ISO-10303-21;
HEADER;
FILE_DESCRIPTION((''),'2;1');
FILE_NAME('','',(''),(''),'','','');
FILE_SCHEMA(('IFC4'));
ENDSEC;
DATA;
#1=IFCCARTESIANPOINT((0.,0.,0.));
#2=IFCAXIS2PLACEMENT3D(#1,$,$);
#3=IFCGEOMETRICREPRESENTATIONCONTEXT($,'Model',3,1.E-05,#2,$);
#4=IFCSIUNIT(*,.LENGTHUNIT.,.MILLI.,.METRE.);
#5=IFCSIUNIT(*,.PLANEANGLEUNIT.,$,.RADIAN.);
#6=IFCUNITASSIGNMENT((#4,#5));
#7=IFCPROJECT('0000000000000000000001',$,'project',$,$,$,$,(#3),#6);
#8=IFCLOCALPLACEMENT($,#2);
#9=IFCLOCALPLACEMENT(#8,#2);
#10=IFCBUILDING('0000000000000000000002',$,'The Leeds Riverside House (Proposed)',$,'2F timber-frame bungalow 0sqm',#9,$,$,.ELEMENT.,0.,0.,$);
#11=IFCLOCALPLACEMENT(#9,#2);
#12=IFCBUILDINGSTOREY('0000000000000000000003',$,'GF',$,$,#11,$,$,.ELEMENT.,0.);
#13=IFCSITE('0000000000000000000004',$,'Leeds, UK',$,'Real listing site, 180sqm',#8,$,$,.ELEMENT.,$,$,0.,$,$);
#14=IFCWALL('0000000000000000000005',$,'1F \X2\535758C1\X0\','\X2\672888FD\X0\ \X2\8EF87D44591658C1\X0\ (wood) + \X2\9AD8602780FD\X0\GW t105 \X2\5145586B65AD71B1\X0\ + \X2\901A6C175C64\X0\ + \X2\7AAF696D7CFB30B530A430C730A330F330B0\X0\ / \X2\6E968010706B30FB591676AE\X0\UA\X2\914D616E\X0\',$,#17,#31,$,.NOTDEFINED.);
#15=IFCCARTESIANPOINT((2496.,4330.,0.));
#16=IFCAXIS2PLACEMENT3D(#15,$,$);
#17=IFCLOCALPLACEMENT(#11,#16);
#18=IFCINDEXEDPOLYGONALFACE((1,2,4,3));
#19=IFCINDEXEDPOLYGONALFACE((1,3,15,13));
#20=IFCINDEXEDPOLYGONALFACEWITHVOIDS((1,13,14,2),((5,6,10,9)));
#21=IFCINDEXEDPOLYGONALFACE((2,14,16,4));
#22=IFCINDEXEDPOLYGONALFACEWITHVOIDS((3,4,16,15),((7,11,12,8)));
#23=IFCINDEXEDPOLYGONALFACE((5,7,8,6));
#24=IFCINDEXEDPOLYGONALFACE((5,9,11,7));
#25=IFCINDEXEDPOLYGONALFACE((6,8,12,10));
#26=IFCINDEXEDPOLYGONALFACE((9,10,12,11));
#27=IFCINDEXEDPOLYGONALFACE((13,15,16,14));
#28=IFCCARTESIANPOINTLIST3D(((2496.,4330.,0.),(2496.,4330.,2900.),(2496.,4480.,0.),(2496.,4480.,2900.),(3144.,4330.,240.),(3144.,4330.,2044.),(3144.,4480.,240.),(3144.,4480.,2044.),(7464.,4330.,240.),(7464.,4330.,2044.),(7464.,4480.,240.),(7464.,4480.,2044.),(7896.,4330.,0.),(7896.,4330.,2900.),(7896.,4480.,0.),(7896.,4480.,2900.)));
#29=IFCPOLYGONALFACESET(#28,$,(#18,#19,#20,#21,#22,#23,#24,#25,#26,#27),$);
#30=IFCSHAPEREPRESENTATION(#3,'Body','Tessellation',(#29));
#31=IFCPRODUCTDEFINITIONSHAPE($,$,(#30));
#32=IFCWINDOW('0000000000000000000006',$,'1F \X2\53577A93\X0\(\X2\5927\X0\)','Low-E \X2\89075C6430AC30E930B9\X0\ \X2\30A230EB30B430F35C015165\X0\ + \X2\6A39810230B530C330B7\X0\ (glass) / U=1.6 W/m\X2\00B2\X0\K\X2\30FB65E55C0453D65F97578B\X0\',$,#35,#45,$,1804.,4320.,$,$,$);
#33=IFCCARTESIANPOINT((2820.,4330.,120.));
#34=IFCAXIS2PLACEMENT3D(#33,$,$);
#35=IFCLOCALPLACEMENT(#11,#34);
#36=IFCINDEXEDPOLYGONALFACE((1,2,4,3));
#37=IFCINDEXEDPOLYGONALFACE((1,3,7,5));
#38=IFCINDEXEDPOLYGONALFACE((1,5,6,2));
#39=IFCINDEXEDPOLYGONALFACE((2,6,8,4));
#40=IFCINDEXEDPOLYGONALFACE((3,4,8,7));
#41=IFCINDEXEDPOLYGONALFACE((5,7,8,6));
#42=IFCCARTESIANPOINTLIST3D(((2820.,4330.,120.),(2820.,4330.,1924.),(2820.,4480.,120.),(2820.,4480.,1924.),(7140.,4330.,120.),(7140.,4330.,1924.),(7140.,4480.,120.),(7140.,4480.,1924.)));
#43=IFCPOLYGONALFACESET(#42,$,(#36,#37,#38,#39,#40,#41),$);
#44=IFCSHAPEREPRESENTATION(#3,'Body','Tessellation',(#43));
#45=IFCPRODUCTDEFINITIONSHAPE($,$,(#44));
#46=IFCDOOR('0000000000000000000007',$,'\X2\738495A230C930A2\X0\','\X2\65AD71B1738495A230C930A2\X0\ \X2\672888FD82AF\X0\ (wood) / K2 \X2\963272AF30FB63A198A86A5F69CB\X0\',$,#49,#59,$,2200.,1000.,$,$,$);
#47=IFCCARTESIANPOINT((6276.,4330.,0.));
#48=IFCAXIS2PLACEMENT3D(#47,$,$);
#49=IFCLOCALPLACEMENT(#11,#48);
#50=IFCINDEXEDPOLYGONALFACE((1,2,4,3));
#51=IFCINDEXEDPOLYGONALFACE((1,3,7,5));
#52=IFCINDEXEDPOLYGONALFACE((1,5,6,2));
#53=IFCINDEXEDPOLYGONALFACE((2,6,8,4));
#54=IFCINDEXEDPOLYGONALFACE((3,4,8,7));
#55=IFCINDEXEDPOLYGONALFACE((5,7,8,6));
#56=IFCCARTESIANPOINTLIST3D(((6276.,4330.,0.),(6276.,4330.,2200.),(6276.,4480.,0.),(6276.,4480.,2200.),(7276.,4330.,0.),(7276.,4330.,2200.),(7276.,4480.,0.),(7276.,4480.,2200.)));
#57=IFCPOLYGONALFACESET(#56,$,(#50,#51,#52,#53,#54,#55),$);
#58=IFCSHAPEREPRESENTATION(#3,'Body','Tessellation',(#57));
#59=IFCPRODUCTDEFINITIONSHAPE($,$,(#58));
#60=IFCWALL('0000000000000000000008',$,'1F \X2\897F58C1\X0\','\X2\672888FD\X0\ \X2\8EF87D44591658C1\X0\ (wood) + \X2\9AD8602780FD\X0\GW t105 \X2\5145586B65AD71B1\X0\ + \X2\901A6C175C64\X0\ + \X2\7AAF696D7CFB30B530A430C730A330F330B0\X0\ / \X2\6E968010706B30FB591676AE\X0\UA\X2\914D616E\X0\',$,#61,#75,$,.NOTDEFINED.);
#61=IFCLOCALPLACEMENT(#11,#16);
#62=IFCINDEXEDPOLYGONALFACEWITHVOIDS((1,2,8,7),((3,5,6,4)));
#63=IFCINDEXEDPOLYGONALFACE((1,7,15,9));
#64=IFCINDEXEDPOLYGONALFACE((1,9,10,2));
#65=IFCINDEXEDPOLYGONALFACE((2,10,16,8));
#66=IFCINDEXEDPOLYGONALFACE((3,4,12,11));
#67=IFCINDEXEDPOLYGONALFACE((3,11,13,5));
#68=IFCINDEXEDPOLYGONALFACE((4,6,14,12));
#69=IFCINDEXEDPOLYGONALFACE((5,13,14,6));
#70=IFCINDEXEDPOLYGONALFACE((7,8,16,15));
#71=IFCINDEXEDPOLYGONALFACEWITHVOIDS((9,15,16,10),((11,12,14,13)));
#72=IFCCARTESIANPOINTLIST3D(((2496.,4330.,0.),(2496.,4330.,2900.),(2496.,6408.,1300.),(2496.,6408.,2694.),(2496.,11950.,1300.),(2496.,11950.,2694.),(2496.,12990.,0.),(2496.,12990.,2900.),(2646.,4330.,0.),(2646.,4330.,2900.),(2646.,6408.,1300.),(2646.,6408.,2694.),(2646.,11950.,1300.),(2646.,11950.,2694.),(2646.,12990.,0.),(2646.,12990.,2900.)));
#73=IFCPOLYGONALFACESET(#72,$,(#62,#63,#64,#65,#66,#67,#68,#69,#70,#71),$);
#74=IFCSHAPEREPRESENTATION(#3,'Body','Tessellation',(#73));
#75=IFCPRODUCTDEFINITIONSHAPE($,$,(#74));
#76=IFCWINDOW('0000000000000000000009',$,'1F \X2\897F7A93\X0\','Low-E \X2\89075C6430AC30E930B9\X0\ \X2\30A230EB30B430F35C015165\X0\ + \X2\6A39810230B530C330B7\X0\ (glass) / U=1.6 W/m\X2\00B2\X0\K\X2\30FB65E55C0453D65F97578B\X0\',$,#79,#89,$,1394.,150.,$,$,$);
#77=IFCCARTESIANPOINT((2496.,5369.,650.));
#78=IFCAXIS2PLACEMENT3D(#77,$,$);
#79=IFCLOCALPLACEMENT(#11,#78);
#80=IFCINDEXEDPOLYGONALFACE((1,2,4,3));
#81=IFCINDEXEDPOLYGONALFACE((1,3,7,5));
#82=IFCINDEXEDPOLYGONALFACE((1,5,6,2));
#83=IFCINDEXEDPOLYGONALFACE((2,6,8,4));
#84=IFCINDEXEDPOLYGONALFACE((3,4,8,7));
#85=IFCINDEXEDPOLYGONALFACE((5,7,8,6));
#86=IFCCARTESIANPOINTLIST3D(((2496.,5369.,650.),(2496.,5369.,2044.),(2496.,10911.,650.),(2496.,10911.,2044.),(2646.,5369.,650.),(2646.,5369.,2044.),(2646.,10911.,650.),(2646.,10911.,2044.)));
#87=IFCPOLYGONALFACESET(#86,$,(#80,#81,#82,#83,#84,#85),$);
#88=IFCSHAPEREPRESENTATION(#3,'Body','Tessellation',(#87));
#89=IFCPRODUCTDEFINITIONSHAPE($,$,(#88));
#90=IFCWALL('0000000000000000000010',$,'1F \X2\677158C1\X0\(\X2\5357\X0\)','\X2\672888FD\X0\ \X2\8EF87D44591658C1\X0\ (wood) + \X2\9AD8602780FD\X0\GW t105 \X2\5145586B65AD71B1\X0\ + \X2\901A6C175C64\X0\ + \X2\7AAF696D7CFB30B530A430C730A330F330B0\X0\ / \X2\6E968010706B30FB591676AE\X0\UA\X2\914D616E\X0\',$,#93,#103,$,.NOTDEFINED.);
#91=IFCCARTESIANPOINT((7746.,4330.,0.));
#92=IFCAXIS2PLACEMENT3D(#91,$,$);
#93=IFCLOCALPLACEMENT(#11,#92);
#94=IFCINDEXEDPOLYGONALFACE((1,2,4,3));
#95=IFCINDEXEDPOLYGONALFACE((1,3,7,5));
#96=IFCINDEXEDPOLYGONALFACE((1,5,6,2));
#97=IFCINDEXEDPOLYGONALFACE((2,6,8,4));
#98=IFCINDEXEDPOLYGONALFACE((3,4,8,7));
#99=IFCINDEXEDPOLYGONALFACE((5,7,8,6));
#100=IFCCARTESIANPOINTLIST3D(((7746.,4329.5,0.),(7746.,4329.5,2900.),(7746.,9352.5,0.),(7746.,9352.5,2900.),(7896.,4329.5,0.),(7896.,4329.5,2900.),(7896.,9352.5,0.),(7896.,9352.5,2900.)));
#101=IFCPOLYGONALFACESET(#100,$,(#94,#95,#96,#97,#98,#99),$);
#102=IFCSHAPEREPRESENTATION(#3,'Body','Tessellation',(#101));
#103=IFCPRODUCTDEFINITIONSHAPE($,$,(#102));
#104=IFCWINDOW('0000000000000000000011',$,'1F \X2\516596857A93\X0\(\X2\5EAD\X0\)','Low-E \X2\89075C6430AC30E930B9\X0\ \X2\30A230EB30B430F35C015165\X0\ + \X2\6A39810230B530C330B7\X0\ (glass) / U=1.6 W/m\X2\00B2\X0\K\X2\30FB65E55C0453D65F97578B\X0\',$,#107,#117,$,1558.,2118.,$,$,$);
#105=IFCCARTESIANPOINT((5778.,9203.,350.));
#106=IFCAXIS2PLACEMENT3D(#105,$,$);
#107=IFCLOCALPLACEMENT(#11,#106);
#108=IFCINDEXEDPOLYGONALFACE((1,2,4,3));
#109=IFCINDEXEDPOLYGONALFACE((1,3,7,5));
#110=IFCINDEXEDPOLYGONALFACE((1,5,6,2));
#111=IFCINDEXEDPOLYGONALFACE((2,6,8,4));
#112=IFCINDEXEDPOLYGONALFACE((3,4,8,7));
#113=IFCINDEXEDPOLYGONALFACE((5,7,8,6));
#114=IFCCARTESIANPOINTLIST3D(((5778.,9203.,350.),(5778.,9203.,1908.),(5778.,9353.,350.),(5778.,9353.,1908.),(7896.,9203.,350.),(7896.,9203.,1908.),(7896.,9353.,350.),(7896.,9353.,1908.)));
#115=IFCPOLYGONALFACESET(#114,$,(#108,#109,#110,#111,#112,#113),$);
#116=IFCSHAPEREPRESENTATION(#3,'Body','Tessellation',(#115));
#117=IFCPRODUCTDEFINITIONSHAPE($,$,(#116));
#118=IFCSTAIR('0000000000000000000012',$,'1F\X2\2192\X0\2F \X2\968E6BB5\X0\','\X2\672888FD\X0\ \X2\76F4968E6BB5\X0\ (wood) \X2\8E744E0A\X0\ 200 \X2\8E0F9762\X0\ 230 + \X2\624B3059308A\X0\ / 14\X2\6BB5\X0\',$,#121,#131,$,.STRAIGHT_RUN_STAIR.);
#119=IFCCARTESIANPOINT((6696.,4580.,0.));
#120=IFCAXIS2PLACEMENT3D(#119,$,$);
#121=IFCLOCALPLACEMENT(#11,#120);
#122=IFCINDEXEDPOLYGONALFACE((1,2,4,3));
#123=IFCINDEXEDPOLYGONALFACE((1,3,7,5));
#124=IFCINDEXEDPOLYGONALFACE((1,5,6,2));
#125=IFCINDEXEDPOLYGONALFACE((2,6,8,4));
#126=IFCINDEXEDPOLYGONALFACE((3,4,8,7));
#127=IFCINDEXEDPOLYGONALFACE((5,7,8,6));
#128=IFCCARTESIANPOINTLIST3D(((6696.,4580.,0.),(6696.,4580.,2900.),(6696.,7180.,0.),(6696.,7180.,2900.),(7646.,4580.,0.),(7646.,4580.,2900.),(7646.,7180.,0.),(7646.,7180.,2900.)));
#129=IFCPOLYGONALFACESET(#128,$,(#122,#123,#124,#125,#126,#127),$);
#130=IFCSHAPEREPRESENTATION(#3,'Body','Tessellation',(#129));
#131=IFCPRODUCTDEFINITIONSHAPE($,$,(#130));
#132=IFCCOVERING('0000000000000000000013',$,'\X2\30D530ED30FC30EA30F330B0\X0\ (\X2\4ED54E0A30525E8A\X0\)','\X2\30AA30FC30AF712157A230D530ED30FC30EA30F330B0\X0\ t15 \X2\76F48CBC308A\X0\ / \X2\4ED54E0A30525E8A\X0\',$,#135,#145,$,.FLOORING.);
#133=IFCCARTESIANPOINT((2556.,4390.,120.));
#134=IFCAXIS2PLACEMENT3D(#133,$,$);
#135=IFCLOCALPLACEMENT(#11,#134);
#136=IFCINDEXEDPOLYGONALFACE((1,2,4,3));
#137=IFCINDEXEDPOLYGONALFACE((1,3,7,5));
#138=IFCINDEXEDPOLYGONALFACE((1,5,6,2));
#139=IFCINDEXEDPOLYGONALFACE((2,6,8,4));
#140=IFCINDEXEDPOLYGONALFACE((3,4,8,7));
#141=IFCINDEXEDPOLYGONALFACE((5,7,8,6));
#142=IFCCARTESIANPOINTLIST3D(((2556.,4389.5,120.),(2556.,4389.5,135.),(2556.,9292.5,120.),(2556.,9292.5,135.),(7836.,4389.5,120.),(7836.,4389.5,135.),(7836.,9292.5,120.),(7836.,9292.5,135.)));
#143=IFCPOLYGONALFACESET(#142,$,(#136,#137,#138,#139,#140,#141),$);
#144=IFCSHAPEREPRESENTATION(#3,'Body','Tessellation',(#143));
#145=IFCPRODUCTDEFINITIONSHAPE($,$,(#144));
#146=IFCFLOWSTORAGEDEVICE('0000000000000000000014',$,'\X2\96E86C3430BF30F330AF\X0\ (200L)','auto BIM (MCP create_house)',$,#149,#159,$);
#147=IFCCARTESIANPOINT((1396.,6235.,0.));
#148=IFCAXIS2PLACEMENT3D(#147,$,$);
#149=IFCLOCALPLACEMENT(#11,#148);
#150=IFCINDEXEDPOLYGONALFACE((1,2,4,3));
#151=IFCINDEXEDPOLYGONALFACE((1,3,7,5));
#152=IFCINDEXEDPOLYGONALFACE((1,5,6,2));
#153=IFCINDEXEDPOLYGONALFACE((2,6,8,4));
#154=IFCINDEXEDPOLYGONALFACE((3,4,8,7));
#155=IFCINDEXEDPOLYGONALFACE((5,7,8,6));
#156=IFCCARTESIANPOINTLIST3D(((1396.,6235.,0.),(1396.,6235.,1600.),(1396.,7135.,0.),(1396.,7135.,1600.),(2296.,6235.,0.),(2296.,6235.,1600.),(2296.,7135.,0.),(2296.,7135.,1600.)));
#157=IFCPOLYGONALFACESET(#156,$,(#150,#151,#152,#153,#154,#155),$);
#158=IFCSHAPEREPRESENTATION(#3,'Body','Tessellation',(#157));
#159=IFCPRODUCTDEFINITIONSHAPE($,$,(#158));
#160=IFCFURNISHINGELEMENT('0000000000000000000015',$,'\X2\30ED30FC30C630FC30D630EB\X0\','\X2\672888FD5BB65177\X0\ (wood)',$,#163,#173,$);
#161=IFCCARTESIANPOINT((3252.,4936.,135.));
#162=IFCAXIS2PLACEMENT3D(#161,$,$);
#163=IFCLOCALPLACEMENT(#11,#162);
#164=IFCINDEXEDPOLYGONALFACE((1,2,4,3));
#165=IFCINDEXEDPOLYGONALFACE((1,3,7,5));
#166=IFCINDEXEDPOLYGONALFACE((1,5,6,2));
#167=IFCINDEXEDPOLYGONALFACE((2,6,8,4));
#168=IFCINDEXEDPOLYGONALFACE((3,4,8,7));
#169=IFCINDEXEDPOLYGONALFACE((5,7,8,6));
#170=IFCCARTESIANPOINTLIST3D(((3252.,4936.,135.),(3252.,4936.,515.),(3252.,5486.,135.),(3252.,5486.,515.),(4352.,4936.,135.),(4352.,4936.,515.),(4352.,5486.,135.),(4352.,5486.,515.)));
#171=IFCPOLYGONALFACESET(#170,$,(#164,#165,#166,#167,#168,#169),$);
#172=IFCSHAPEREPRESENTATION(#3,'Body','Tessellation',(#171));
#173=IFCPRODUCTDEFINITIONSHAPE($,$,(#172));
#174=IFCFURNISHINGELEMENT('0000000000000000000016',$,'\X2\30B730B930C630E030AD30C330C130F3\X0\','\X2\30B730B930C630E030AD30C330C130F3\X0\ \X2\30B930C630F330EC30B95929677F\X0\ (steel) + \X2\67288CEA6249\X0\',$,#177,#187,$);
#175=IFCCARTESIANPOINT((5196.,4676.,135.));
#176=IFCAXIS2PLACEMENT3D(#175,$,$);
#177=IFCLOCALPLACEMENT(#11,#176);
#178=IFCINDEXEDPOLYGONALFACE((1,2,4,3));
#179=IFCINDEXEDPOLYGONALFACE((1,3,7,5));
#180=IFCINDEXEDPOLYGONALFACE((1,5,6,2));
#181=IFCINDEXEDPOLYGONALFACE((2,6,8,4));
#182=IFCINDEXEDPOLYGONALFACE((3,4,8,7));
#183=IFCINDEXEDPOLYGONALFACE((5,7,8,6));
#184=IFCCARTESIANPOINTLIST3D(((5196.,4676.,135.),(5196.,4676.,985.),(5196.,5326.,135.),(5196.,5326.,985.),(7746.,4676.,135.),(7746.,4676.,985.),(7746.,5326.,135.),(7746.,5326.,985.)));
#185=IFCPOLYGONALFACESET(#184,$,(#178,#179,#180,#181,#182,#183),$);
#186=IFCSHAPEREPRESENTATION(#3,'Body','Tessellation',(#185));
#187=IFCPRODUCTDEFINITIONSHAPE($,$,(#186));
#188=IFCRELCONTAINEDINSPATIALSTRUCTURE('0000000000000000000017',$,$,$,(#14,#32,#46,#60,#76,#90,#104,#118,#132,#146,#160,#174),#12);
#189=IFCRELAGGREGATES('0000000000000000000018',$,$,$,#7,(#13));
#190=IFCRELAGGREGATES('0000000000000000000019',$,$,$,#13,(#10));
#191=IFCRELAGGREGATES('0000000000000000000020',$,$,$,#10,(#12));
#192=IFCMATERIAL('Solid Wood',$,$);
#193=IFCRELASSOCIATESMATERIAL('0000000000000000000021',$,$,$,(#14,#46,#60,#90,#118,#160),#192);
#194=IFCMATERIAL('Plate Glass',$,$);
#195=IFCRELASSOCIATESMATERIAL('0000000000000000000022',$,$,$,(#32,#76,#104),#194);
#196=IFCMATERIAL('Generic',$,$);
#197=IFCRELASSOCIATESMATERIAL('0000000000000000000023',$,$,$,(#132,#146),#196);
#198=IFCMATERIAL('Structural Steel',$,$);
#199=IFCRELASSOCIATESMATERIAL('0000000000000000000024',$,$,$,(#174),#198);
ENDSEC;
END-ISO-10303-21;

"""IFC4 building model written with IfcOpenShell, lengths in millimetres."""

from ifc_helpers import new_model, si_unit, frame, frame_2d, origin, place, context, project, spatial, rectangle, extrude, material, element, fill, save


model = new_model("IFC4")

# Units and contexts
model_context = context("Model", 3, precision=1e-05, world=origin())
ifc_project = project(units=[si_unit("LENGTHUNIT", "METRE", prefix="MILLI"), si_unit("PLANEANGLEUNIT", "RADIAN")], contexts=[model_context])

# Site, building, storey
site_placement = place(None, origin())
site = spatial("IfcSite", under=ifc_project, at=site_placement, Name="Leeds, UK", ObjectType="Real listing site, 180sqm", CompositionType="ELEMENT", RefElevation=0.0)
building_placement = place(site_placement, origin())
building = spatial("IfcBuilding", under=site, at=building_placement, Name="The Leeds Riverside House (Proposed)", ObjectType="2F timber-frame bungalow 0sqm", CompositionType="ELEMENT", ElevationOfRefHeight=0.0, ElevationOfTerrain=0.0)
storey_placement = place(building_placement, origin())
storey = spatial("IfcBuildingStorey", under=building, at=storey_placement, Name="GF", CompositionType="ELEMENT", Elevation=0.0)

# Shared definitions
ifc_material_1 = material(Name="Solid Wood")

# Wall, openings, window, door
wall_1_placement = place(storey_placement, frame((2496.0, 4330.0, 0.0)))
wall_1 = element("IfcWall", 1, at=wall_1_placement, inside=storey, material=ifc_material_1, Name="1F 南壁", Description="木製 軸組外壁 (wood) + 高性能GW t105 充填断熱 + 通気層 + 窯業系サイディング / 準耐火・外皮UA配慮", PredefinedType="NOTDEFINED", context=model_context, shape_type="SweptSolid", body=[
    extrude(rectangle(XDim=5400.0, YDim=150.0, at=frame_2d((2700.0, 75.0))), frame((2496.0, 4330.0, 0.0)), (0.0, 0.0, 1.0), 2900.0),
])
opening_1_placement = place(storey_placement, frame((2820.0, 4330.0, 120.0)))
opening_1 = element("IfcOpeningElement", 2, at=opening_1_placement, cuts=wall_1, PredefinedType="NOTDEFINED", context=model_context, shape_type="SweptSolid", body=[
    extrude(rectangle(XDim=4320.0, YDim=150.0, at=frame_2d((2160.0, 75.0))), frame((2820.0, 4330.0, 120.0)), (0.0, 0.0, 1.0), 1804.0),
])
opening_2_placement = place(storey_placement, frame((6276.0, 4330.0, 0.0)))
opening_2 = element("IfcOpeningElement", 3, at=opening_2_placement, cuts=wall_1, PredefinedType="NOTDEFINED", context=model_context, shape_type="SweptSolid", body=[
    extrude(rectangle(XDim=1000.0, YDim=150.0, at=frame_2d((500.0, 75.0))), frame((6276.0, 4330.0, 0.0)), (0.0, 0.0, 1.0), 2200.0),
])
ifc_material_2 = material(Name="Plate Glass")
window_1_placement = place(storey_placement, frame((2820.0, 4330.0, 120.0)))
window_1 = element("IfcWindow", 4, at=window_1_placement, inside=storey, material=ifc_material_2, Name="1F 南窓(大)", Description="Low-E 複層ガラス アルゴン封入 + 樹脂サッシ (glass) / U=1.6 W/m²K・日射取得型", OverallHeight=1804.0, OverallWidth=4320.0, context=model_context, shape_type="SweptSolid", body=[
    extrude(rectangle(XDim=4320.0, YDim=150.0, at=frame_2d((2160.0, 75.0))), frame((2820.0, 4330.0, 120.0)), (0.0, 0.0, 1.0), 1804.0),
])
fill(opening_1, window_1)
door_1_placement = place(storey_placement, frame((6276.0, 4330.0, 0.0)))
door_1 = element("IfcDoor", 5, at=door_1_placement, inside=storey, material=ifc_material_1, Name="玄関ドア", Description="断熱玄関ドア 木製芯 (wood) / K2 防犯・採風機構", OverallHeight=2200.0, OverallWidth=1000.0, context=model_context, shape_type="SweptSolid", body=[
    extrude(rectangle(XDim=1000.0, YDim=150.0, at=frame_2d((500.0, 75.0))), frame((6276.0, 4330.0, 0.0)), (0.0, 0.0, 1.0), 2200.0),
])
fill(opening_2, door_1)

# Walls, openings, windows
wall_2_placement = place(storey_placement, frame((2496.0, 4330.0, 0.0)))
wall_2 = element("IfcWall", 6, at=wall_2_placement, inside=storey, material=ifc_material_1, Name="1F 西壁", Description="木製 軸組外壁 (wood) + 高性能GW t105 充填断熱 + 通気層 + 窯業系サイディング / 準耐火・外皮UA配慮", PredefinedType="NOTDEFINED", context=model_context, shape_type="SweptSolid", body=[
    extrude(rectangle(XDim=150.0, YDim=8660.0, at=frame_2d((75.0, 4330.0))), frame((2496.0, 4330.0, 0.0)), (0.0, 0.0, 1.0), 2900.0),
])
opening_3_placement = place(storey_placement, frame((2496.0, 5369.0, 650.0)))
opening_3 = element("IfcOpeningElement", 7, at=opening_3_placement, cuts=wall_2, PredefinedType="NOTDEFINED", context=model_context, shape_type="SweptSolid", body=[
    extrude(rectangle(XDim=150.0, YDim=5542.0, at=frame_2d((75.0, 2771.0))), frame((2496.0, 5369.0, 650.0)), (0.0, 0.0, 1.0), 1394.0),
])
window_2_placement = place(storey_placement, frame((2496.0, 5369.0, 650.0)))
window_2 = element("IfcWindow", 8, at=window_2_placement, inside=storey, material=ifc_material_2, Name="1F 西窓", Description="Low-E 複層ガラス アルゴン封入 + 樹脂サッシ (glass) / U=1.6 W/m²K・日射取得型", OverallHeight=1394.0, OverallWidth=150.0, context=model_context, shape_type="SweptSolid", body=[
    extrude(rectangle(XDim=150.0, YDim=5542.0, at=frame_2d((75.0, 2771.0))), frame((2496.0, 5369.0, 650.0)), (0.0, 0.0, 1.0), 1394.0),
])
fill(opening_3, window_2)
wall_3_placement = place(storey_placement, frame((7746.0, 4330.0, 0.0)))
wall_3 = element("IfcWall", 9, at=wall_3_placement, inside=storey, material=ifc_material_1, Name="1F 東壁(南)", Description="木製 軸組外壁 (wood) + 高性能GW t105 充填断熱 + 通気層 + 窯業系サイディング / 準耐火・外皮UA配慮", PredefinedType="NOTDEFINED", context=model_context, shape_type="SweptSolid", body=[
    extrude(rectangle(XDim=150.0, YDim=5023.0, at=frame_2d((75.0, 2511.0))), frame((7746.0, 4330.0, 0.0)), (0.0, 0.0, 1.0), 2900.0),
])
opening_4_placement = place(storey_placement, frame((5778.0, 9203.0, 350.0)))
opening_4 = element("IfcOpeningElement", 10, at=opening_4_placement, cuts=wall_3, PredefinedType="NOTDEFINED", context=model_context, shape_type="SweptSolid", body=[
    extrude(rectangle(XDim=2118.0, YDim=150.0, at=frame_2d((1059.0, 75.0))), frame((5778.0, 9203.0, 350.0)), (0.0, 0.0, 1.0), 1558.0),
])
window_3_placement = place(storey_placement, frame((5778.0, 9203.0, 350.0)))
window_3 = element("IfcWindow", 11, at=window_3_placement, inside=storey, material=ifc_material_2, Name="1F 入隅窓(庭)", Description="Low-E 複層ガラス アルゴン封入 + 樹脂サッシ (glass) / U=1.6 W/m²K・日射取得型", OverallHeight=1558.0, OverallWidth=2118.0, context=model_context, shape_type="SweptSolid", body=[
    extrude(rectangle(XDim=2118.0, YDim=150.0, at=frame_2d((1059.0, 75.0))), frame((5778.0, 9203.0, 350.0)), (0.0, 0.0, 1.0), 1558.0),
])
fill(opening_4, window_3)

# Stair
stair_placement = place(storey_placement, frame((6696.0, 4580.0, 0.0)))
element("IfcStair", 12, at=stair_placement, inside=storey, material=ifc_material_1, Name="1F→2F 階段", Description="木製 直階段 (wood) 蹴上 200 踏面 230 + 手すり / 14段", PredefinedType="STRAIGHT_RUN_STAIR", context=model_context, shape_type="SweptSolid", body=[
    extrude(rectangle(XDim=950.0, YDim=2600.0, at=frame_2d((475.0, 1300.0))), frame((6696.0, 4580.0, 0.0)), (0.0, 0.0, 1.0), 2900.0),
])

# Covering
ifc_material_3 = material(Name="Generic")
covering_placement = place(storey_placement, frame((2556.0, 4390.0, 120.0)))
element("IfcCovering", 13, at=covering_placement, inside=storey, material=ifc_material_3, Name="フローリング (仕上げ床)", Description="オーク無垢フローリング t15 直貼り / 仕上げ床", PredefinedType="FLOORING", context=model_context, shape_type="SweptSolid", body=[
    extrude(rectangle(XDim=5280.0, YDim=4903.0, at=frame_2d((2640.0, 2451.0))), frame((2556.0, 4390.0, 120.0)), (0.0, 0.0, 1.0), 15.0),
])

# Flow storage device
flow_storage_device_placement = place(storey_placement, frame((1396.0, 6235.0, 0.0)))
element("IfcFlowStorageDevice", 14, at=flow_storage_device_placement, inside=storey, material=ifc_material_3, Name="雨水タンク (200L)", Description="auto BIM (MCP create_house)", context=model_context, shape_type="SweptSolid", body=[
    extrude(rectangle(XDim=900.0, YDim=900.0, at=frame_2d((450.0, 450.0))), frame((1396.0, 6235.0, 0.0)), (0.0, 0.0, 1.0), 1600.0),
])

# Furnishing elements
furnishing_1_placement = place(storey_placement, frame((3252.0, 4936.0, 135.0)))
element("IfcFurnishingElement", 15, at=furnishing_1_placement, inside=storey, material=ifc_material_1, Name="ローテーブル", Description="木製家具 (wood)", context=model_context, shape_type="SweptSolid", body=[
    extrude(rectangle(XDim=1100.0, YDim=550.0, at=frame_2d((550.0, 275.0))), frame((3252.0, 4936.0, 135.0)), (0.0, 0.0, 1.0), 380.0),
])
ifc_material_4 = material(Name="Structural Steel")
furnishing_2_placement = place(storey_placement, frame((5196.0, 4676.0, 135.0)))
element("IfcFurnishingElement", 16, at=furnishing_2_placement, inside=storey, material=ifc_material_4, Name="システムキッチン", Description="システムキッチン ステンレス天板 (steel) + 木質扉", context=model_context, shape_type="SweptSolid", body=[
    extrude(rectangle(XDim=2550.0, YDim=650.0, at=frame_2d((1275.0, 325.0))), frame((5196.0, 4676.0, 135.0)), (0.0, 0.0, 1.0), 850.0),
])

save(model, "model.ifc")
